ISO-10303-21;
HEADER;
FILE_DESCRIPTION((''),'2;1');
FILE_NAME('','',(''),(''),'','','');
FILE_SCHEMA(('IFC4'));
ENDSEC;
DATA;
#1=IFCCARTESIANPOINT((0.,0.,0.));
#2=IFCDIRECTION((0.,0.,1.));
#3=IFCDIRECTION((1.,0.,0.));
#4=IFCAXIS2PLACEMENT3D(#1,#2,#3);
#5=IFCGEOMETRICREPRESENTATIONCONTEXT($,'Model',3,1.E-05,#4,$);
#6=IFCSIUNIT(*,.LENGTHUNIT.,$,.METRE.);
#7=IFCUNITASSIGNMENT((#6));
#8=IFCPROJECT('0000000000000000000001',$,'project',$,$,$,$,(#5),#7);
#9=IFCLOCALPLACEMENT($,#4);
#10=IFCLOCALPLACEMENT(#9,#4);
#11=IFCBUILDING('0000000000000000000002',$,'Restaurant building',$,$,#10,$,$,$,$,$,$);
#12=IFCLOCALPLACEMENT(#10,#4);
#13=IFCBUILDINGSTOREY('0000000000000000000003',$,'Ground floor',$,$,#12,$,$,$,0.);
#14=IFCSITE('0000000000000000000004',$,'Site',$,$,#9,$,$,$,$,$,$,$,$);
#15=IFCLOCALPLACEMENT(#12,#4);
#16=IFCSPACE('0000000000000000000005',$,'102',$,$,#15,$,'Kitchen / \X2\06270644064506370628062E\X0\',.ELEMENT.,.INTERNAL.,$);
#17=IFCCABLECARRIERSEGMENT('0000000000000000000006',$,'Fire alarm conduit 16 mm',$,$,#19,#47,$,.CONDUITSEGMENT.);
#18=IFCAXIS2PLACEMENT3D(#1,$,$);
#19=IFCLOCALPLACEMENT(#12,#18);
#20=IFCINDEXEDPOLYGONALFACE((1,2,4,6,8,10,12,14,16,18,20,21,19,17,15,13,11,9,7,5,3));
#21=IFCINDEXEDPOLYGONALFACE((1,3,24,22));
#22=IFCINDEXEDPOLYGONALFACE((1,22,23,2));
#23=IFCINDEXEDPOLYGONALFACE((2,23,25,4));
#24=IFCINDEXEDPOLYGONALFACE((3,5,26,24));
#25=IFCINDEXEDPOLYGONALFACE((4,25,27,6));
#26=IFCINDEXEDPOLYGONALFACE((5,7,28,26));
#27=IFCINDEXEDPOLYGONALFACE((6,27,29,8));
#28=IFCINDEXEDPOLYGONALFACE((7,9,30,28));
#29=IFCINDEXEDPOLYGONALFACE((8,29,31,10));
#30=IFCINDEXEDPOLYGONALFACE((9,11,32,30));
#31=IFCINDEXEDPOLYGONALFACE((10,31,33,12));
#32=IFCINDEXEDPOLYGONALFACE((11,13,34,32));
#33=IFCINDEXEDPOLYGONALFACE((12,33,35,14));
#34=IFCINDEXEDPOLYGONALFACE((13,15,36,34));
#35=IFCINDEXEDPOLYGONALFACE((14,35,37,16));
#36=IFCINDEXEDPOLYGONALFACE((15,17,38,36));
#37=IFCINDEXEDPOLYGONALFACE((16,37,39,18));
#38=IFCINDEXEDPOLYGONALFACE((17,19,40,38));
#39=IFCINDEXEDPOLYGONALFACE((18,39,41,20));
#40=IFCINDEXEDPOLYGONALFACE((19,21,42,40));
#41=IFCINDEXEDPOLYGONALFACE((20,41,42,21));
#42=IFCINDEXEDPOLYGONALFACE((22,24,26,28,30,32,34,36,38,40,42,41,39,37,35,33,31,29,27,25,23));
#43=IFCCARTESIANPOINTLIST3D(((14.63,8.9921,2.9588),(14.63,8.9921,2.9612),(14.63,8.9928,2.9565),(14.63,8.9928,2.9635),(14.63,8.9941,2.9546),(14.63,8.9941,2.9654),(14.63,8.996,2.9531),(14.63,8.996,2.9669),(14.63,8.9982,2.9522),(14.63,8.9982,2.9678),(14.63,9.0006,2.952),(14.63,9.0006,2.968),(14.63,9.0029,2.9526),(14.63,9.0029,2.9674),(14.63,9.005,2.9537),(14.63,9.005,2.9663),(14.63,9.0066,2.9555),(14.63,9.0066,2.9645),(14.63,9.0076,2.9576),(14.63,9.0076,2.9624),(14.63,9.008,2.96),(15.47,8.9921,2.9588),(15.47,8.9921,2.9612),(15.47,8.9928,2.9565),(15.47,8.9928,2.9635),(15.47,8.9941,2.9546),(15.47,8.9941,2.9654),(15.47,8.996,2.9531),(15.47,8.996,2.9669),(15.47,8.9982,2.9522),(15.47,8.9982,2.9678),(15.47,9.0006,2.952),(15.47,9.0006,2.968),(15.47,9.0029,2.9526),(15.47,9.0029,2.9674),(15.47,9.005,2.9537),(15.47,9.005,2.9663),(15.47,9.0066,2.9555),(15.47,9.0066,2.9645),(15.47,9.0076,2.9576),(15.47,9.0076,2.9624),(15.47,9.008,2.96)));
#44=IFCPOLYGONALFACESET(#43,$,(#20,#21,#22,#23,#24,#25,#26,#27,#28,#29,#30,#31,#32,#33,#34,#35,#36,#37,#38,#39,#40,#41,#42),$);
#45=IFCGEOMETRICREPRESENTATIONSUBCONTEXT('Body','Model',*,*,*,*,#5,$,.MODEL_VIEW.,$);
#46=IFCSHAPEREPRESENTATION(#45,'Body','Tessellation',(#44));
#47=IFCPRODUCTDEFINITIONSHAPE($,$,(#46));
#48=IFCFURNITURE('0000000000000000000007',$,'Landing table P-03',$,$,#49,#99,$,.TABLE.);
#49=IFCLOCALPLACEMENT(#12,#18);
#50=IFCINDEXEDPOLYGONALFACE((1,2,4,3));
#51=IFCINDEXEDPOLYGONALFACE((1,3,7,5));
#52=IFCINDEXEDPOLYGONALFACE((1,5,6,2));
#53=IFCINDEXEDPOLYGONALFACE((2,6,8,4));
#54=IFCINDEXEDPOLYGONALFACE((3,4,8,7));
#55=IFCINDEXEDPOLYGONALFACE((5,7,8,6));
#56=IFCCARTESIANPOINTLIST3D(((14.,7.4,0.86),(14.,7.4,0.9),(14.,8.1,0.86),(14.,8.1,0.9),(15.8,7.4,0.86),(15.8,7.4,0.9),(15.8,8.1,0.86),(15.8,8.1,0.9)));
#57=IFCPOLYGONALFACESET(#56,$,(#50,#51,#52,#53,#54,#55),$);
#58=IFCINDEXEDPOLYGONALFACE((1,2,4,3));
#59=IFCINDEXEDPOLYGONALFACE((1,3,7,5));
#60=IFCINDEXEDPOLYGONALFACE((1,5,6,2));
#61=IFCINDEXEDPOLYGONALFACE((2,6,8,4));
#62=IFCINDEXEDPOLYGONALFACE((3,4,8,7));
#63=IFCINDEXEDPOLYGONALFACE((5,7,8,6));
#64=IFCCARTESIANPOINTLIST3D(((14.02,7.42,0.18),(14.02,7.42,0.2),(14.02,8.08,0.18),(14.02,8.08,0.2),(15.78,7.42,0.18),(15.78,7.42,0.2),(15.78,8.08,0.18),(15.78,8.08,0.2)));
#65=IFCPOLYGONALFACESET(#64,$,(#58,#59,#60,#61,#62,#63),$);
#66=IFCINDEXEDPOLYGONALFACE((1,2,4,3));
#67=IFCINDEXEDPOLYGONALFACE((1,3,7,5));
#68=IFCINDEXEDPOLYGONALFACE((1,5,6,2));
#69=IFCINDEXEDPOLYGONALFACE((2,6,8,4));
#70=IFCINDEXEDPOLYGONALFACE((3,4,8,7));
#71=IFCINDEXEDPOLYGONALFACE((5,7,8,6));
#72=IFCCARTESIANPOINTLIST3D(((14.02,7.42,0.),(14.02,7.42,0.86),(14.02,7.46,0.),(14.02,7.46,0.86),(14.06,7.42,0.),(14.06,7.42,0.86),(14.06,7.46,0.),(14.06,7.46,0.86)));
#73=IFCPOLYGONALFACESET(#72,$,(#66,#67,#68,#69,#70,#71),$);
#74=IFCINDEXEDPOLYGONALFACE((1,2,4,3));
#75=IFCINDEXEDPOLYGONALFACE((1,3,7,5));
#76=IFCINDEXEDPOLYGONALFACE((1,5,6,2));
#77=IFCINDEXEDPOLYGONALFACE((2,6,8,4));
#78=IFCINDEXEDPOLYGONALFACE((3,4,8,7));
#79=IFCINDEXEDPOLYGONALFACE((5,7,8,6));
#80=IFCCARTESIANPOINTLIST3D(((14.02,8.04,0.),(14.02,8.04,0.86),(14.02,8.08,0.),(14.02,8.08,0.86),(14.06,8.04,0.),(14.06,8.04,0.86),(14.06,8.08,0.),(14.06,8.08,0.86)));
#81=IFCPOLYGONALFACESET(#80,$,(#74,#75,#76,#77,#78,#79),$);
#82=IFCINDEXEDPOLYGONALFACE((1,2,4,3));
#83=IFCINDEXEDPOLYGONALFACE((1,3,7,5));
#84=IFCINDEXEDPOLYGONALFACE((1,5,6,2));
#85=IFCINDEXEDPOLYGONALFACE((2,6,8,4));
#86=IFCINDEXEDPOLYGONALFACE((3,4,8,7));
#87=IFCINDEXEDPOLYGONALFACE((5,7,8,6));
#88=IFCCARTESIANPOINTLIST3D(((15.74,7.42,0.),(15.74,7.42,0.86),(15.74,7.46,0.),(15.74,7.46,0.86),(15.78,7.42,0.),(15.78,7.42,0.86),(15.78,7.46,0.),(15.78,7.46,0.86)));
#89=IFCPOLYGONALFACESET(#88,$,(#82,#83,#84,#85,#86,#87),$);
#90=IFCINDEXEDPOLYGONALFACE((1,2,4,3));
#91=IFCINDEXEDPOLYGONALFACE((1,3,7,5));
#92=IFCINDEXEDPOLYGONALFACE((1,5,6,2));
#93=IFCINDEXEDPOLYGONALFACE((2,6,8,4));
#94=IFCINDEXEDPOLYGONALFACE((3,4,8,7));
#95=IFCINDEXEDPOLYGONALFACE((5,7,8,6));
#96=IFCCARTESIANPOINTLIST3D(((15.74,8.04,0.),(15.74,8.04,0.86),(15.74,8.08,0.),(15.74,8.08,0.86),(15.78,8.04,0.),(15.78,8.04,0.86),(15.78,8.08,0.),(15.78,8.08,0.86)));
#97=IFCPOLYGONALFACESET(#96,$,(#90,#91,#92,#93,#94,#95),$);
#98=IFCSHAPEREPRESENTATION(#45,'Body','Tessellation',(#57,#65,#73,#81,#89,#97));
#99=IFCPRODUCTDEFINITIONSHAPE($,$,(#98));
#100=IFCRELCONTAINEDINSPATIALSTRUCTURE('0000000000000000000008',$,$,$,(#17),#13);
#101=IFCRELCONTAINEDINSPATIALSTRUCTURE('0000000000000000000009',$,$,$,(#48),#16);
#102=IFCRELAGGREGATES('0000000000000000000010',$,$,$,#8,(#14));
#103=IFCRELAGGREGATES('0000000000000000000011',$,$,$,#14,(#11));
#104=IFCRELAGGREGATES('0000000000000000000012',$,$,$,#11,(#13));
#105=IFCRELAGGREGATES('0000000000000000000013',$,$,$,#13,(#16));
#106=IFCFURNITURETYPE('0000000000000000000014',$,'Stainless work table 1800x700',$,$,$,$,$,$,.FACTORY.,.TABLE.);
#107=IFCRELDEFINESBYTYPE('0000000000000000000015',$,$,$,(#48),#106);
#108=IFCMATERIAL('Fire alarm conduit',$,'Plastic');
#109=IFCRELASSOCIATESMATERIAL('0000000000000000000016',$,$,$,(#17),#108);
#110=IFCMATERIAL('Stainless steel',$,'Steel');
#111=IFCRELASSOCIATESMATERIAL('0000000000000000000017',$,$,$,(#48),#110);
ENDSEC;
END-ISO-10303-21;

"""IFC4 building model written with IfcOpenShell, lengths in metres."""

from ifc_helpers import new_model, si_unit, frame, origin, origin_with_axes, origin_2d, place, context, subcontext, project, spatial, rectangle, circle, extrude, source, transform, mapped, material, type_object, type_shapes, element, save


model = new_model("IFC4")

# Units and contexts
model_context = context("Model", 3, precision=1e-05, world=origin_with_axes())
body_context = subcontext(model_context, "Body", "Model", "MODEL_VIEW")
ifc_project = project(units=[si_unit("LENGTHUNIT", "METRE")], contexts=[model_context])

# Site, building, storey
site_placement = place(None, origin_with_axes())
site = spatial("IfcSite", under=ifc_project, at=site_placement, Name="Site")
building_placement = place(site_placement, origin_with_axes())
building = spatial("IfcBuilding", under=site, at=building_placement, Name="Restaurant building")
storey_placement = place(building_placement, origin_with_axes())
storey = spatial("IfcBuildingStorey", under=building, at=storey_placement, Name="Ground floor", Elevation=0.0)

# Shared definitions
space_placement = place(storey_placement, origin_with_axes())
space = spatial("IfcSpace", under=storey, at=space_placement, Name="102", LongName="Kitchen / المطبخ", CompositionType="ELEMENT", PredefinedType="INTERNAL")

# Cable carrier segment
ifc_material_1 = material(Name="Fire alarm conduit", Category="Plastic")
cable_carrier_segment_1_placement = place(storey_placement, frame((14.63, 9.0, 2.96)))
element("IfcCableCarrierSegment", 1, at=cable_carrier_segment_1_placement, inside=storey, material=ifc_material_1, Name="Fire alarm conduit 16 mm", PredefinedType="CONDUITSEGMENT", context=body_context, shape_type="SweptSolid", body=[
    extrude(circle(Radius=0.008, at=origin_2d()), frame((0.0, 0.0, 0.0), z_axis=(1.0, 0.0, 0.0), x_axis=(0.0, 1.0, 0.0)), (0.0, 0.0, 1.0), 0.84),
])

# Furniture
ifc_material_2 = material(Name="Stainless steel", Category="Steel")
furniture_type = type_object("IfcFurnitureType", Name="Stainless work table 1800x700", AssemblyPlace="FACTORY", PredefinedType="TABLE")
shared_shape_1 = source(origin(), body_context, "Body", "SweptSolid", [
    extrude(rectangle(XDim=1.8, YDim=0.7, at=origin_2d()), frame((0.0, 0.0, 0.86)), (0.0, 0.0, 1.0), 0.04),
    extrude(rectangle(XDim=1.76, YDim=0.66, at=origin_2d()), frame((0.0, 0.0, 0.18)), (0.0, 0.0, 1.0), 0.02),
    extrude(rectangle(XDim=0.04, YDim=0.04, at=origin_2d()), frame((-0.86, -0.31, 0.0)), (0.0, 0.0, 1.0), 0.86),
    extrude(rectangle(XDim=0.04, YDim=0.04, at=origin_2d()), frame((-0.86, 0.31, 0.0)), (0.0, 0.0, 1.0), 0.86),
    extrude(rectangle(XDim=0.04, YDim=0.04, at=origin_2d()), frame((0.86, -0.31, 0.0)), (0.0, 0.0, 1.0), 0.86),
    extrude(rectangle(XDim=0.04, YDim=0.04, at=origin_2d()), frame((0.86, 0.31, 0.0)), (0.0, 0.0, 1.0), 0.86),
])
type_shapes(furniture_type, [shared_shape_1])
furniture_placement = place(storey_placement, frame((14.9, 7.75, 0.0)))
element("IfcFurniture", 2, at=furniture_placement, inside=space, type_object=furniture_type, material=ifc_material_2, Name="Landing table P-03", PredefinedType="TABLE", context=body_context, shape_type="MappedRepresentation", body=[
    mapped(shared_shape_1, transform((0.0, 0.0, 0.0))),
])

save(model, "model.ifc")
